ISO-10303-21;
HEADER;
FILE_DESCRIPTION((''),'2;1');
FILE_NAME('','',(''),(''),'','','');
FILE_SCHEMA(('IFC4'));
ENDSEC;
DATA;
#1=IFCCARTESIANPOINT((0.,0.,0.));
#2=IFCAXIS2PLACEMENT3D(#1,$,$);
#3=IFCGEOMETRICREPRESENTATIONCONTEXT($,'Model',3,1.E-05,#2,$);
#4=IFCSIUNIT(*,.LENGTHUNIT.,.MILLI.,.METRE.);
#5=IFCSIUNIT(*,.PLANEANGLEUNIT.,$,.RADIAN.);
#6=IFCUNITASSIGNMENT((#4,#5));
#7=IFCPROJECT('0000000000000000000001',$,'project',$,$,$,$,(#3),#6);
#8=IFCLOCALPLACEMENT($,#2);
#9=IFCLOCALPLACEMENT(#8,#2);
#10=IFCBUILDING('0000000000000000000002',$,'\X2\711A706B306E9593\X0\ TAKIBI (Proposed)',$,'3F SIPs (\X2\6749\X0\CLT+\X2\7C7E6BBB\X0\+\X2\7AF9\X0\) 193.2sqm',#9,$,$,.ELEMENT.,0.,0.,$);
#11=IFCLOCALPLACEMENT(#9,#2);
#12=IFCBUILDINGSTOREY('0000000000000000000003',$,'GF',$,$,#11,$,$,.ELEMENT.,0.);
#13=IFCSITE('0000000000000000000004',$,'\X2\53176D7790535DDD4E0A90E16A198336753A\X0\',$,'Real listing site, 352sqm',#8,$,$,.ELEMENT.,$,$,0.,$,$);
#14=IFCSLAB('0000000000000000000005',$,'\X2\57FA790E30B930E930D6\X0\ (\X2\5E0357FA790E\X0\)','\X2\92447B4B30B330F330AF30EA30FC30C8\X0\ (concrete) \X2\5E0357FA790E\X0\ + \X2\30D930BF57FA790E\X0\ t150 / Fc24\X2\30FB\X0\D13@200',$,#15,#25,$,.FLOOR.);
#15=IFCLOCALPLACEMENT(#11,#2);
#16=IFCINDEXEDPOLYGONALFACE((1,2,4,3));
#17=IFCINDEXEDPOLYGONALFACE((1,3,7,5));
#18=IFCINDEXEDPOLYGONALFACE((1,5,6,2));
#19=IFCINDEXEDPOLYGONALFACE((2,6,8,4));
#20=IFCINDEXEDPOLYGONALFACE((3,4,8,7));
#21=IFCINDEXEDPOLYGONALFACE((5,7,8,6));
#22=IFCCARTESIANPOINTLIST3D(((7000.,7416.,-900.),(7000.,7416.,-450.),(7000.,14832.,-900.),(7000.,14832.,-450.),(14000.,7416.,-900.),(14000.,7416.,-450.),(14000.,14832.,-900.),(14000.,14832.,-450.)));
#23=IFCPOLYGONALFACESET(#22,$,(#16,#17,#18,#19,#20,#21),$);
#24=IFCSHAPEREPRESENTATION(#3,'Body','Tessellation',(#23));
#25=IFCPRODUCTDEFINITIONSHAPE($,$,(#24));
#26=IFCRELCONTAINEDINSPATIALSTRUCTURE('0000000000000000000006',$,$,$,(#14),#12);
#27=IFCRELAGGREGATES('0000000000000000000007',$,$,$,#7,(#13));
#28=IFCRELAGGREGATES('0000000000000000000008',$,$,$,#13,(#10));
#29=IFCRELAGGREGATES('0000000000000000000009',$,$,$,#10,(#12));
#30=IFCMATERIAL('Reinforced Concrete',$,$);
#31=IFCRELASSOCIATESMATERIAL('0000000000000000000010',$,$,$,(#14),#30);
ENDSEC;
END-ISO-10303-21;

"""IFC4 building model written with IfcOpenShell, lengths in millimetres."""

from ifc_helpers import new_model, si_unit, frame, frame_2d, origin, place, context, project, spatial, rectangle, extrude, material, element, save


model = new_model("IFC4")

# Units and contexts
model_context = context("Model", 3, precision=1e-05, world=origin())
ifc_project = project(units=[si_unit("LENGTHUNIT", "METRE", prefix="MILLI"), si_unit("PLANEANGLEUNIT", "RADIAN")], contexts=[model_context])

# Site, building, storey
site_placement = place(None, origin())
site = spatial("IfcSite", under=ifc_project, at=site_placement, Name="北海道川上郡標茶町", ObjectType="Real listing site, 352sqm", CompositionType="ELEMENT", RefElevation=0.0)
building_placement = place(site_placement, origin())
building = spatial("IfcBuilding", under=site, at=building_placement, Name="焚火の間 TAKIBI (Proposed)", ObjectType="3F SIPs (杉CLT+籾殻+竹) 193.2sqm", CompositionType="ELEMENT", ElevationOfRefHeight=0.0, ElevationOfTerrain=0.0)
storey_placement = place(building_placement, origin())
storey = spatial("IfcBuildingStorey", under=building, at=storey_placement, Name="GF", CompositionType="ELEMENT", Elevation=0.0)

# Slab
ifc_material_1 = material(Name="Reinforced Concrete")
slab_1_placement = place(storey_placement, frame((3500.0, 3708.0, -450.0)))
element("IfcSlab", 1, at=slab_1_placement, inside=storey, material=ifc_material_1, Name="基礎スラブ (布基礎)", Description="鉄筋コンクリート (concrete) 布基礎 + ベタ基礎 t150 / Fc24・D13@200", PredefinedType="FLOOR", context=model_context, shape_type="SweptSolid", body=[
    extrude(rectangle(XDim=7000.0, YDim=7416.0, at=frame_2d((3500.0, 3708.0))), frame((3500.0, 3708.0, -450.0)), (0.0, 0.0, 1.0), 450.0),
])

save(model, "model.ifc")
